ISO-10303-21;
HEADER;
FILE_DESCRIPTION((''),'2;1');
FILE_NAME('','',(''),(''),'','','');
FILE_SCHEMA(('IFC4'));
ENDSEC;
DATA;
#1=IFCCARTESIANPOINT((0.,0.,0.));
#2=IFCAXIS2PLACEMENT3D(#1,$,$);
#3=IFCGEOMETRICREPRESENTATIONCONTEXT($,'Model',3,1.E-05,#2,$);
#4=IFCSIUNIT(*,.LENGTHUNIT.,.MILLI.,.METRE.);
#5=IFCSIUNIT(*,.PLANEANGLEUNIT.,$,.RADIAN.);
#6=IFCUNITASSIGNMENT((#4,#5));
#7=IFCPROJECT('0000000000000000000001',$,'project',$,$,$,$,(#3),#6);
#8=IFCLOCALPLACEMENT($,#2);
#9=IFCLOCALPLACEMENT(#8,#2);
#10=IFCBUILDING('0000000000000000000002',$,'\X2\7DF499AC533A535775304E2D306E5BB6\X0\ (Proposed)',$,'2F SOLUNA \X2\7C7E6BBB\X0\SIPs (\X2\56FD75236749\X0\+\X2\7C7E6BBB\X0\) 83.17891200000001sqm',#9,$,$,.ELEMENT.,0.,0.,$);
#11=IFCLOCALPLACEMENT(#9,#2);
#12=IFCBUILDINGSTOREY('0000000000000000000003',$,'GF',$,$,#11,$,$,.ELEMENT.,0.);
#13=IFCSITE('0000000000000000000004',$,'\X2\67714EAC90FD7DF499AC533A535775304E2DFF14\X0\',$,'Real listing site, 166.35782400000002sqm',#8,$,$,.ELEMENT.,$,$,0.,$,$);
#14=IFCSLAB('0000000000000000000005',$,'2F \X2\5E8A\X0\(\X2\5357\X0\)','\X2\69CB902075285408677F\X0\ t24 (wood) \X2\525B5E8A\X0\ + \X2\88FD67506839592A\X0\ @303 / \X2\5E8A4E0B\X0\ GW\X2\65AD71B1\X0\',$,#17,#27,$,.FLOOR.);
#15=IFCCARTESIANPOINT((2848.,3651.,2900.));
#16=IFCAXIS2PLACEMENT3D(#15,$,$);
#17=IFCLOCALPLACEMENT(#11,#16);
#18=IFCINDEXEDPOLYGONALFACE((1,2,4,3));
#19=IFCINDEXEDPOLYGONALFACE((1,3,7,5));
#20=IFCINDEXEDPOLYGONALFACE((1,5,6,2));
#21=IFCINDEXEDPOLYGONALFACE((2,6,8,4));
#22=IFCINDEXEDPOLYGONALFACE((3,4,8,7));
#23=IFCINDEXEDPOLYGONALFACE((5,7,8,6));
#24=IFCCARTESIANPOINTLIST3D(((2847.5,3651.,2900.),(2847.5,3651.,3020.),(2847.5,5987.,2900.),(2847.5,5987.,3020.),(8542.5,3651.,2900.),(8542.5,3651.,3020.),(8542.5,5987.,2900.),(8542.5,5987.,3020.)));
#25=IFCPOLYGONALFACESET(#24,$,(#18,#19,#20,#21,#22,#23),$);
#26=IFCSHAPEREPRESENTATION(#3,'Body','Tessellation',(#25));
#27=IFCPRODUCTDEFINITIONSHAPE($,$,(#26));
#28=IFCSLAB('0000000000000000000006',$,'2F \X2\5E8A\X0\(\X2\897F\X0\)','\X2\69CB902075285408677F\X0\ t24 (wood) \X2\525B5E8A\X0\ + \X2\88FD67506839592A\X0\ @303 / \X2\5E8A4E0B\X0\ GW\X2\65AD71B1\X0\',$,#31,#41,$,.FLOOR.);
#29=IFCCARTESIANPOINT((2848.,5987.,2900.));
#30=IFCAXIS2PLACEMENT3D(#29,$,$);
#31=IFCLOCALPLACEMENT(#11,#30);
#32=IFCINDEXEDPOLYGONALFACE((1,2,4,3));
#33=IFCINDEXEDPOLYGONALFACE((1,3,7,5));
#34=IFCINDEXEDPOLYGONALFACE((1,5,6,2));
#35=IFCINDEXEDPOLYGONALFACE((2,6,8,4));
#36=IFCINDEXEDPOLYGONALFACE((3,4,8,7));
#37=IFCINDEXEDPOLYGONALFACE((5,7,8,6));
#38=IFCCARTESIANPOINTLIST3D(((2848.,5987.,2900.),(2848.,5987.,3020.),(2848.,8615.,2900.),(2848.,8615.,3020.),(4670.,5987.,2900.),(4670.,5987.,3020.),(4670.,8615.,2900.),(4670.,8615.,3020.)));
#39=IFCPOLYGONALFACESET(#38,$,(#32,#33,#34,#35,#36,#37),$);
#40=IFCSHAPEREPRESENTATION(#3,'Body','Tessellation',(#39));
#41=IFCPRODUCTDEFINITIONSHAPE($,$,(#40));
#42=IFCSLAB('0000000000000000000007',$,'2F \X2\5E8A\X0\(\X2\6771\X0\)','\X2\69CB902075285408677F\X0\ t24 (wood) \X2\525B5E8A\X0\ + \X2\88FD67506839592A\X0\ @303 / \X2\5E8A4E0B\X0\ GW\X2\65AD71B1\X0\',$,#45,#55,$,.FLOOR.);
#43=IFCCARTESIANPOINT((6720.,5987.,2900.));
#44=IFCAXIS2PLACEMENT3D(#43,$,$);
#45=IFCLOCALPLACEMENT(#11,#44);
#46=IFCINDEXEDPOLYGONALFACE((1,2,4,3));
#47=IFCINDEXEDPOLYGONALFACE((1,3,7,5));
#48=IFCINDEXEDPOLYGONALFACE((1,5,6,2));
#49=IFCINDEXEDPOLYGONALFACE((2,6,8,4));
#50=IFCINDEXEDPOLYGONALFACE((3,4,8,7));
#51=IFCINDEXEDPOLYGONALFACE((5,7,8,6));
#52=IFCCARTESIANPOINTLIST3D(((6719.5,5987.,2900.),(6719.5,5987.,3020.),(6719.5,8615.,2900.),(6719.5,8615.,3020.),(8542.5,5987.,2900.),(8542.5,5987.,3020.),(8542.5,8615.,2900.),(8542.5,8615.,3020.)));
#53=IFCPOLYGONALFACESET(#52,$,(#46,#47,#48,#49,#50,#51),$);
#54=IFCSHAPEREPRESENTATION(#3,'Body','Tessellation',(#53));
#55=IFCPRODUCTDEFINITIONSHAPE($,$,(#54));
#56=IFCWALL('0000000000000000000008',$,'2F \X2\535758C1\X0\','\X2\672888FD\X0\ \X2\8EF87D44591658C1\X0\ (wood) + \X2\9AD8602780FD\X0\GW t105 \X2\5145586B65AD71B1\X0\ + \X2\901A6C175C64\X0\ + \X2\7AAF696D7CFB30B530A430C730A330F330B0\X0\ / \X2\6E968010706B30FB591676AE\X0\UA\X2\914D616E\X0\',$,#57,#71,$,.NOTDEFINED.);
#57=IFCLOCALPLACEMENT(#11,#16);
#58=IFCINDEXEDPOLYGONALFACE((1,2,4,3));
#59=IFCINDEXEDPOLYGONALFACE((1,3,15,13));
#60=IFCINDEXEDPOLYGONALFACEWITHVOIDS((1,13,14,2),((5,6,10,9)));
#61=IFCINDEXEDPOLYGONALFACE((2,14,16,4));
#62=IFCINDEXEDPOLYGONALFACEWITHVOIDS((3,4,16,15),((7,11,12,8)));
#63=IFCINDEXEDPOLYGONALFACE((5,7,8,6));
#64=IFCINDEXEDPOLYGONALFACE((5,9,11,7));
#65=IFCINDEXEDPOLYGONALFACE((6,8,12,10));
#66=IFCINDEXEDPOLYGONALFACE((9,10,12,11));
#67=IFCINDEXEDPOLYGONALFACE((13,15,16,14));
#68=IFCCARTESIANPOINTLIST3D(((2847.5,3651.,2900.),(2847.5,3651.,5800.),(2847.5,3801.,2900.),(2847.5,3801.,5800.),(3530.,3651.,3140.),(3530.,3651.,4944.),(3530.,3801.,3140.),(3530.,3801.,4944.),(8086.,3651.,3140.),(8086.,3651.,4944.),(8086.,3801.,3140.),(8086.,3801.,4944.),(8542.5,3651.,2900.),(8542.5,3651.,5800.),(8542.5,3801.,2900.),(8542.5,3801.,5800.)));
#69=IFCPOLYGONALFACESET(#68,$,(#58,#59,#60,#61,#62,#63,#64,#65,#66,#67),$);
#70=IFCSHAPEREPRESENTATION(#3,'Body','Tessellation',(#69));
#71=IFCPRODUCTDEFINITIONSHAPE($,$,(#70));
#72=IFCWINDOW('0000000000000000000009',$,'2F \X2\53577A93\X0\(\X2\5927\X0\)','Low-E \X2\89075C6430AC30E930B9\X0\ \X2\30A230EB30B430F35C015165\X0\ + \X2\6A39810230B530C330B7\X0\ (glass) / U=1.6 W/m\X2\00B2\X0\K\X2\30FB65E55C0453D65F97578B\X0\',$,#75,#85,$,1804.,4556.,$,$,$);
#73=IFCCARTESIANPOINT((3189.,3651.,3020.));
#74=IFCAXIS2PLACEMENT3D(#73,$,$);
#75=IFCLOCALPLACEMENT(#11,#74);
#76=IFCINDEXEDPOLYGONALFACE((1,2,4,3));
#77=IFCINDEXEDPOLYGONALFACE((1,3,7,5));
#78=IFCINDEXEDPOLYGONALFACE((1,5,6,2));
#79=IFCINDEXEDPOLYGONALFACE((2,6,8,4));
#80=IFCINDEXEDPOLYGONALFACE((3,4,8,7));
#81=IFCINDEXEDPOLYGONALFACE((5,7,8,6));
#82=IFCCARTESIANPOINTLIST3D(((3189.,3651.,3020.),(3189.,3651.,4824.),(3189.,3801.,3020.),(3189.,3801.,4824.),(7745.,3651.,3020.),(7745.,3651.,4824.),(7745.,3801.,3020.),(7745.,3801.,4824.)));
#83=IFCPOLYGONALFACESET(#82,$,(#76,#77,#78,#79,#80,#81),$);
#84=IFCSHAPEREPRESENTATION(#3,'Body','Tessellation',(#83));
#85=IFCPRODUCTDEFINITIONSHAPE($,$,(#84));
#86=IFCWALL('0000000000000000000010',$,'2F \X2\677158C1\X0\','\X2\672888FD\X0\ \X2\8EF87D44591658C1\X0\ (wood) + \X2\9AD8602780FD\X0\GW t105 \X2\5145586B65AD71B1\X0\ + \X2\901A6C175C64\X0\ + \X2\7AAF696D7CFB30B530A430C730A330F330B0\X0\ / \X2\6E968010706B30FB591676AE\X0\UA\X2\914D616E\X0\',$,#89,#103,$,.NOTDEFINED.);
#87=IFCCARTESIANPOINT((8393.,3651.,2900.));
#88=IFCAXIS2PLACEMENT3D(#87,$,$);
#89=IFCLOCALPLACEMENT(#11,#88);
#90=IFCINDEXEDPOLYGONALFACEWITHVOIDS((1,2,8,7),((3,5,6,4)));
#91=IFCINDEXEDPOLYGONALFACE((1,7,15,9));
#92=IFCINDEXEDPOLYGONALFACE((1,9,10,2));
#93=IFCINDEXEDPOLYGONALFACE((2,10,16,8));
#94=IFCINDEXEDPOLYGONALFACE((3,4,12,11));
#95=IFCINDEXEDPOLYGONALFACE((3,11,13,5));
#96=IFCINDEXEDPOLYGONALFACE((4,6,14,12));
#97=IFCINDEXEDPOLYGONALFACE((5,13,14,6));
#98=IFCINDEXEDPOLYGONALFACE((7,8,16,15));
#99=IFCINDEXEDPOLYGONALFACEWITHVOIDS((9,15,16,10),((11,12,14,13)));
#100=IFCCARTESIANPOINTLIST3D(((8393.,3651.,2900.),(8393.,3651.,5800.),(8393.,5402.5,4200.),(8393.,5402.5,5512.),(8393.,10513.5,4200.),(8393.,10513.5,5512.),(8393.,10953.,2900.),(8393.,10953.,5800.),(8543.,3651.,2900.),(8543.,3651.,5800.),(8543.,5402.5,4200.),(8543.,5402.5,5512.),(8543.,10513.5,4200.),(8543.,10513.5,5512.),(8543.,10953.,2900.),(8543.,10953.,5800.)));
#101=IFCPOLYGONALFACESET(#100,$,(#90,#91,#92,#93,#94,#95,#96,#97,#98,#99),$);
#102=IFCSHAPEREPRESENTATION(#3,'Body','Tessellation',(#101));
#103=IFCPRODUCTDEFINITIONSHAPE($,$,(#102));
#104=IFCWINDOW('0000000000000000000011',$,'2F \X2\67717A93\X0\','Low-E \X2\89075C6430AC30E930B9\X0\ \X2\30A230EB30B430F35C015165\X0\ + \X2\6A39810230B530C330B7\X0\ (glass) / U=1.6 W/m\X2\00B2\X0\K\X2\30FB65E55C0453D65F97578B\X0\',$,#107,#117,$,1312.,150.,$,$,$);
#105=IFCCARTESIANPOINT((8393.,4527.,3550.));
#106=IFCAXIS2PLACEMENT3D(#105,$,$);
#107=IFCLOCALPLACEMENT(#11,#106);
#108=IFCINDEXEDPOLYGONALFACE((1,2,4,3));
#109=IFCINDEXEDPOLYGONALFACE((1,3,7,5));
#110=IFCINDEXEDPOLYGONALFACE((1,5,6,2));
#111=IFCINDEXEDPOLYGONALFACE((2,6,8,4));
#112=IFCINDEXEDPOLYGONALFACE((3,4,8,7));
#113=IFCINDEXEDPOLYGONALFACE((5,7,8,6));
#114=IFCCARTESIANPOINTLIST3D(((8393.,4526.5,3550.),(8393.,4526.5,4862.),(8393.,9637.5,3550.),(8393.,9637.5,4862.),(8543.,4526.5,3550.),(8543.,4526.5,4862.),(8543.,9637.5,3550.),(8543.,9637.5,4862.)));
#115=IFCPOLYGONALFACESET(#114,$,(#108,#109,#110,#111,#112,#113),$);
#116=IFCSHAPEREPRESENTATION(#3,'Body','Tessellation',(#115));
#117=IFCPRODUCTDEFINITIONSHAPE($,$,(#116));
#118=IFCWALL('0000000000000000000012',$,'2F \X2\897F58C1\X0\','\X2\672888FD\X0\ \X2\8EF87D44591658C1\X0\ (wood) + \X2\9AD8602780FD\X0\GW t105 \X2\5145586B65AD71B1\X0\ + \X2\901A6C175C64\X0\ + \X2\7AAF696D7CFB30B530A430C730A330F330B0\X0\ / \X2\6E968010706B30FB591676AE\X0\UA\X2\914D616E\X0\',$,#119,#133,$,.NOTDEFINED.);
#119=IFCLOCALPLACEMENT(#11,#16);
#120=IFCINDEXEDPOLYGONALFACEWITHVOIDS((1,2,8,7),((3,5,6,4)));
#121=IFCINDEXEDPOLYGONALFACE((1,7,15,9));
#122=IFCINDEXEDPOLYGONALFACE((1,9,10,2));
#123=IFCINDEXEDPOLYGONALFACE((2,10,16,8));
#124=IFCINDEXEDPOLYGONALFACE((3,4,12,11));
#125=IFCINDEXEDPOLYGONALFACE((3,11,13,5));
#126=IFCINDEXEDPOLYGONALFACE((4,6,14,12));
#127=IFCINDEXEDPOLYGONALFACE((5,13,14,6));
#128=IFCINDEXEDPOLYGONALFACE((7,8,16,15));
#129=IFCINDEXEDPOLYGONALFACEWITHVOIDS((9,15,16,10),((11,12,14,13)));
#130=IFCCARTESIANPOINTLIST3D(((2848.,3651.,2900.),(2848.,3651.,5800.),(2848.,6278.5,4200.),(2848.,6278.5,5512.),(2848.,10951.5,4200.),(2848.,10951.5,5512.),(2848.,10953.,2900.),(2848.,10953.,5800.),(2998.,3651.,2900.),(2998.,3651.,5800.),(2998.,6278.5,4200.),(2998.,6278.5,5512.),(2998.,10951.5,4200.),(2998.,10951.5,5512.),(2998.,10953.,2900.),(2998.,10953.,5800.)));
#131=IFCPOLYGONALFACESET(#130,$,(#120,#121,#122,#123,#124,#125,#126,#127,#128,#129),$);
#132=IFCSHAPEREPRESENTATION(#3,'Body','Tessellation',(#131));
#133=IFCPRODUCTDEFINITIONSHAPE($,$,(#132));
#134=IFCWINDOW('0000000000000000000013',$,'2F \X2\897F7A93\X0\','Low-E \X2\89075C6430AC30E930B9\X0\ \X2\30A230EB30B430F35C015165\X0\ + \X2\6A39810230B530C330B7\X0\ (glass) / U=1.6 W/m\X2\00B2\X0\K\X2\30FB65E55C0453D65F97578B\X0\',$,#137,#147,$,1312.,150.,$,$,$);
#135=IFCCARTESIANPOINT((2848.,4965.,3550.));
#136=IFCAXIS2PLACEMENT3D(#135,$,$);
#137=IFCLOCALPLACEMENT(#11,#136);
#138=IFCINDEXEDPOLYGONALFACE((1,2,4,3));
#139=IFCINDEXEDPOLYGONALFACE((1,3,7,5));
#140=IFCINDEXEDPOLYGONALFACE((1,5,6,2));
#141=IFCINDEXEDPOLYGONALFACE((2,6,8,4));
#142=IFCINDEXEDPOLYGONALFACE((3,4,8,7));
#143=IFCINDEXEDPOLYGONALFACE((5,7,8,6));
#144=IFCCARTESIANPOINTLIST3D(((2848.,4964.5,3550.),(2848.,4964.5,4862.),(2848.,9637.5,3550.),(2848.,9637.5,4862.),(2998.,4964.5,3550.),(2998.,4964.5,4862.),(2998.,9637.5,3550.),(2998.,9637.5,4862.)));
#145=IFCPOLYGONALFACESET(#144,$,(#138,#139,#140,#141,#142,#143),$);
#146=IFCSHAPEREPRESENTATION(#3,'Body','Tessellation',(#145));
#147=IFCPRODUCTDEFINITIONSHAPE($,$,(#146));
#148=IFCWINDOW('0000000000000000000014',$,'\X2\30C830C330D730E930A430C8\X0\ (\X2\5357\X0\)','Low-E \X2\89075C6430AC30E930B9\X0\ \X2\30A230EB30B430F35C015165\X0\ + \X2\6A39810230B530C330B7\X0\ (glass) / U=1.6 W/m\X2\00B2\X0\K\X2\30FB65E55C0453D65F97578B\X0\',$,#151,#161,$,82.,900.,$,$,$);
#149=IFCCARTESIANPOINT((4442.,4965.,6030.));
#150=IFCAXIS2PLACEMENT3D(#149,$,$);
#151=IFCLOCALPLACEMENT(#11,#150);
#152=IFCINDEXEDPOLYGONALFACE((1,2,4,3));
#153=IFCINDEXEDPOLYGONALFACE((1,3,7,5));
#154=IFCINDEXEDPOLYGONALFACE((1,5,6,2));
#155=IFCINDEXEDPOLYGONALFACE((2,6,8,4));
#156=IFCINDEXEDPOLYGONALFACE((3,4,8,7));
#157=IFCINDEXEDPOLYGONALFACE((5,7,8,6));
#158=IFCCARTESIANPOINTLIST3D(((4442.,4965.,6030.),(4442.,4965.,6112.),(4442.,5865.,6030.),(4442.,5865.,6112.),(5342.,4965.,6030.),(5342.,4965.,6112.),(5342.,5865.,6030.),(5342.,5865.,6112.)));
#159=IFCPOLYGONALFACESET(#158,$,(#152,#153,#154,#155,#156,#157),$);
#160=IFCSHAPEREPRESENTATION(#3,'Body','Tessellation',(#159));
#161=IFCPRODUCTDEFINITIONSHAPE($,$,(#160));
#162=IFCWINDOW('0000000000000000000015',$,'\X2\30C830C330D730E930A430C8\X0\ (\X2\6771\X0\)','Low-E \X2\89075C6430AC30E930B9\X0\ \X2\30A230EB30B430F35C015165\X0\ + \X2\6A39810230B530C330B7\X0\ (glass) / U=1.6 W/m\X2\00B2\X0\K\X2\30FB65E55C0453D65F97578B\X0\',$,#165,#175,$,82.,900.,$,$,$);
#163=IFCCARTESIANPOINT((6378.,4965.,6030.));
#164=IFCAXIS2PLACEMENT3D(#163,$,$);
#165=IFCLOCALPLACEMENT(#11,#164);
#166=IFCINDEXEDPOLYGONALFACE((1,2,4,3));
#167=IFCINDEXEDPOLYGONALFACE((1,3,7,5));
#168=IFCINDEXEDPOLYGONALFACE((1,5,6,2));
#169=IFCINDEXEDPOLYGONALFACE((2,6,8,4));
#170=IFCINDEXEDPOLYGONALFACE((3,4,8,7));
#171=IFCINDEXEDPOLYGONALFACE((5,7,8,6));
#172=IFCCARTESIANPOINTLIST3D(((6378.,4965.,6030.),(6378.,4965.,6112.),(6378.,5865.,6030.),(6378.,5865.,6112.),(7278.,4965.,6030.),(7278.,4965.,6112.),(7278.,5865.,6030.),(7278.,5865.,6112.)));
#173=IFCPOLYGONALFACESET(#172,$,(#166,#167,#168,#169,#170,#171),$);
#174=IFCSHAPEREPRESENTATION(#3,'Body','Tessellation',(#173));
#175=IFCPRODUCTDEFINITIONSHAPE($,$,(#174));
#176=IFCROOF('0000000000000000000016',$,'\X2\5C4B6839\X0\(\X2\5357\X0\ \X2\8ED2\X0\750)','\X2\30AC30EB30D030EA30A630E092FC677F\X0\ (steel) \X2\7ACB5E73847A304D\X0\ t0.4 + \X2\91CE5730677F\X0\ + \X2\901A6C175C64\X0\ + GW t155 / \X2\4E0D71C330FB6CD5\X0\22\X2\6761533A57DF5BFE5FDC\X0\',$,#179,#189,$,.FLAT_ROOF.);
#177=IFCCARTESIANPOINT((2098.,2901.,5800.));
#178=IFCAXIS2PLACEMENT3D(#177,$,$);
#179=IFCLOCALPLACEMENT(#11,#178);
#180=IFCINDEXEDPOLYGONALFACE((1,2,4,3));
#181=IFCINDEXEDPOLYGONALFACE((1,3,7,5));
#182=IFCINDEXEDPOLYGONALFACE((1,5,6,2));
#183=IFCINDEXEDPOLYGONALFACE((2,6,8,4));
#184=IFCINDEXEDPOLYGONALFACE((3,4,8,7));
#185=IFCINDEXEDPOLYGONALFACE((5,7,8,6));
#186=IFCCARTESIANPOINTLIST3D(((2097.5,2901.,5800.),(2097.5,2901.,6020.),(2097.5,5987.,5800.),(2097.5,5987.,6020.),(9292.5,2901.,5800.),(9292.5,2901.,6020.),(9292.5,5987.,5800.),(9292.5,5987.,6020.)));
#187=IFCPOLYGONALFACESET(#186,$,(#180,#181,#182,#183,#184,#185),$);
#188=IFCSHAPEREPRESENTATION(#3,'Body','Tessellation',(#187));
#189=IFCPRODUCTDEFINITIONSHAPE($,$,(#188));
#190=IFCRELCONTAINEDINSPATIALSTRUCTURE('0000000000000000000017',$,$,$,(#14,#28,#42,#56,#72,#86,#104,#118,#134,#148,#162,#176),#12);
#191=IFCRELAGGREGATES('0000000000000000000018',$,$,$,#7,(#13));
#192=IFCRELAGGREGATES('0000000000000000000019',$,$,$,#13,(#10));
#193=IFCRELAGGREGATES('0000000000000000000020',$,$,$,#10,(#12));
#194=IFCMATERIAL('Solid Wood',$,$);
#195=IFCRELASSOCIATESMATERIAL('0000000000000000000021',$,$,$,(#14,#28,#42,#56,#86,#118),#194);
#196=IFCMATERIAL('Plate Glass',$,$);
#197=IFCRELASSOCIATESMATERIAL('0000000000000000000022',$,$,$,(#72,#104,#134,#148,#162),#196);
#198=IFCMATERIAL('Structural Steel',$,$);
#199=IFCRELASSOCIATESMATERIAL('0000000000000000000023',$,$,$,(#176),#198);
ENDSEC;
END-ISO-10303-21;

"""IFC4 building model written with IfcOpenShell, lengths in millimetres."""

from ifc_helpers import new_model, si_unit, frame, frame_2d, origin, place, context, project, spatial, rectangle, extrude, material, element, fill, save


model = new_model("IFC4")

# Units and contexts
model_context = context("Model", 3, precision=1e-05, world=origin())
ifc_project = project(units=[si_unit("LENGTHUNIT", "METRE", prefix="MILLI"), si_unit("PLANEANGLEUNIT", "RADIAN")], contexts=[model_context])

# Site, building, storey
site_placement = place(None, origin())
site = spatial("IfcSite", under=ifc_project, at=site_placement, Name="東京都練馬区南田中４", ObjectType="Real listing site, 166.35782400000002sqm", CompositionType="ELEMENT", RefElevation=0.0)
building_placement = place(site_placement, origin())
building = spatial("IfcBuilding", under=site, at=building_placement, Name="練馬区南田中の家 (Proposed)", ObjectType="2F SOLUNA 籾殻SIPs (国産杉+籾殻) 83.17891200000001sqm", CompositionType="ELEMENT", ElevationOfRefHeight=0.0, ElevationOfTerrain=0.0)
storey_placement = place(building_placement, origin())
storey = spatial("IfcBuildingStorey", under=building, at=storey_placement, Name="GF", CompositionType="ELEMENT", Elevation=0.0)

# Slabs
ifc_material_1 = material(Name="Solid Wood")
slab_1_placement = place(storey_placement, frame((2848.0, 3651.0, 2900.0)))
element("IfcSlab", 1, at=slab_1_placement, inside=storey, material=ifc_material_1, Name="2F 床(南)", Description="構造用合板 t24 (wood) 剛床 + 製材根太 @303 / 床下 GW断熱", PredefinedType="FLOOR", context=model_context, shape_type="SweptSolid", body=[
    extrude(rectangle(XDim=5695.0, YDim=2336.0, at=frame_2d((2847.0, 1168.0))), frame((2848.0, 3651.0, 2900.0)), (0.0, 0.0, 1.0), 120.0),
])
slab_2_placement = place(storey_placement, frame((2848.0, 5987.0, 2900.0)))
element("IfcSlab", 2, at=slab_2_placement, inside=storey, material=ifc_material_1, Name="2F 床(西)", Description="構造用合板 t24 (wood) 剛床 + 製材根太 @303 / 床下 GW断熱", PredefinedType="FLOOR", context=model_context, shape_type="SweptSolid", body=[
    extrude(rectangle(XDim=1822.0, YDim=2628.0, at=frame_2d((911.0, 1314.0))), frame((2848.0, 5987.0, 2900.0)), (0.0, 0.0, 1.0), 120.0),
])
slab_3_placement = place(storey_placement, frame((6720.0, 5987.0, 2900.0)))
element("IfcSlab", 3, at=slab_3_placement, inside=storey, material=ifc_material_1, Name="2F 床(東)", Description="構造用合板 t24 (wood) 剛床 + 製材根太 @303 / 床下 GW断熱", PredefinedType="FLOOR", context=model_context, shape_type="SweptSolid", body=[
    extrude(rectangle(XDim=1823.0, YDim=2628.0, at=frame_2d((911.0, 1314.0))), frame((6720.0, 5987.0, 2900.0)), (0.0, 0.0, 1.0), 120.0),
])

# Walls, openings, windows
wall_1_placement = place(storey_placement, frame((2848.0, 3651.0, 2900.0)))
wall_1 = element("IfcWall", 4, at=wall_1_placement, inside=storey, material=ifc_material_1, Name="2F 南壁", Description="木製 軸組外壁 (wood) + 高性能GW t105 充填断熱 + 通気層 + 窯業系サイディング / 準耐火・外皮UA配慮", PredefinedType="NOTDEFINED", context=model_context, shape_type="SweptSolid", body=[
    extrude(rectangle(XDim=5695.0, YDim=150.0, at=frame_2d((2847.0, 75.0))), frame((2848.0, 3651.0, 2900.0)), (0.0, 0.0, 1.0), 2900.0),
])
opening_1_placement = place(storey_placement, frame((3189.0, 3651.0, 3020.0)))
opening_1 = element("IfcOpeningElement", 5, at=opening_1_placement, cuts=wall_1, PredefinedType="NOTDEFINED", context=model_context, shape_type="SweptSolid", body=[
    extrude(rectangle(XDim=4556.0, YDim=150.0, at=frame_2d((2278.0, 75.0))), frame((3189.0, 3651.0, 3020.0)), (0.0, 0.0, 1.0), 1804.0),
])
ifc_material_2 = material(Name="Plate Glass")
window_1_placement = place(storey_placement, frame((3189.0, 3651.0, 3020.0)))
window_1 = element("IfcWindow", 6, at=window_1_placement, inside=storey, material=ifc_material_2, Name="2F 南窓(大)", Description="Low-E 複層ガラス アルゴン封入 + 樹脂サッシ (glass) / U=1.6 W/m²K・日射取得型", OverallHeight=1804.0, OverallWidth=4556.0, context=model_context, shape_type="SweptSolid", body=[
    extrude(rectangle(XDim=4556.0, YDim=150.0, at=frame_2d((2278.0, 75.0))), frame((3189.0, 3651.0, 3020.0)), (0.0, 0.0, 1.0), 1804.0),
])
fill(opening_1, window_1)
wall_2_placement = place(storey_placement, frame((8393.0, 3651.0, 2900.0)))
wall_2 = element("IfcWall", 7, at=wall_2_placement, inside=storey, material=ifc_material_1, Name="2F 東壁", Description="木製 軸組外壁 (wood) + 高性能GW t105 充填断熱 + 通気層 + 窯業系サイディング / 準耐火・外皮UA配慮", PredefinedType="NOTDEFINED", context=model_context, shape_type="SweptSolid", body=[
    extrude(rectangle(XDim=150.0, YDim=7302.0, at=frame_2d((75.0, 3651.0))), frame((8393.0, 3651.0, 2900.0)), (0.0, 0.0, 1.0), 2900.0),
])
opening_2_placement = place(storey_placement, frame((8393.0, 4527.0, 3550.0)))
opening_2 = element("IfcOpeningElement", 8, at=opening_2_placement, cuts=wall_2, PredefinedType="NOTDEFINED", context=model_context, shape_type="SweptSolid", body=[
    extrude(rectangle(XDim=150.0, YDim=5111.0, at=frame_2d((75.0, 2555.0))), frame((8393.0, 4527.0, 3550.0)), (0.0, 0.0, 1.0), 1312.0),
])
window_2_placement = place(storey_placement, frame((8393.0, 4527.0, 3550.0)))
window_2 = element("IfcWindow", 9, at=window_2_placement, inside=storey, material=ifc_material_2, Name="2F 東窓", Description="Low-E 複層ガラス アルゴン封入 + 樹脂サッシ (glass) / U=1.6 W/m²K・日射取得型", OverallHeight=1312.0, OverallWidth=150.0, context=model_context, shape_type="SweptSolid", body=[
    extrude(rectangle(XDim=150.0, YDim=5111.0, at=frame_2d((75.0, 2555.0))), frame((8393.0, 4527.0, 3550.0)), (0.0, 0.0, 1.0), 1312.0),
])
fill(opening_2, window_2)
wall_3_placement = place(storey_placement, frame((2848.0, 3651.0, 2900.0)))
wall_3 = element("IfcWall", 10, at=wall_3_placement, inside=storey, material=ifc_material_1, Name="2F 西壁", Description="木製 軸組外壁 (wood) + 高性能GW t105 充填断熱 + 通気層 + 窯業系サイディング / 準耐火・外皮UA配慮", PredefinedType="NOTDEFINED", context=model_context, shape_type="SweptSolid", body=[
    extrude(rectangle(XDim=150.0, YDim=7302.0, at=frame_2d((75.0, 3651.0))), frame((2848.0, 3651.0, 2900.0)), (0.0, 0.0, 1.0), 2900.0),
])
opening_3_placement = place(storey_placement, frame((2848.0, 4965.0, 3550.0)))
opening_3 = element("IfcOpeningElement", 11, at=opening_3_placement, cuts=wall_3, PredefinedType="NOTDEFINED", context=model_context, shape_type="SweptSolid", body=[
    extrude(rectangle(XDim=150.0, YDim=4673.0, at=frame_2d((75.0, 2336.0))), frame((2848.0, 4965.0, 3550.0)), (0.0, 0.0, 1.0), 1312.0),
])
window_3_placement = place(storey_placement, frame((2848.0, 4965.0, 3550.0)))
window_3 = element("IfcWindow", 12, at=window_3_placement, inside=storey, material=ifc_material_2, Name="2F 西窓", Description="Low-E 複層ガラス アルゴン封入 + 樹脂サッシ (glass) / U=1.6 W/m²K・日射取得型", OverallHeight=1312.0, OverallWidth=150.0, context=model_context, shape_type="SweptSolid", body=[
    extrude(rectangle(XDim=150.0, YDim=4673.0, at=frame_2d((75.0, 2336.0))), frame((2848.0, 4965.0, 3550.0)), (0.0, 0.0, 1.0), 1312.0),
])
fill(opening_3, window_3)

# Windows
window_4_placement = place(storey_placement, frame((4442.0, 4965.0, 6030.0)))
element("IfcWindow", 13, at=window_4_placement, inside=storey, material=ifc_material_2, Name="トップライト (南)", Description="Low-E 複層ガラス アルゴン封入 + 樹脂サッシ (glass) / U=1.6 W/m²K・日射取得型", OverallHeight=82.0, OverallWidth=900.0, context=model_context, shape_type="SweptSolid", body=[
    extrude(rectangle(XDim=900.0, YDim=900.0, at=frame_2d((450.0, 450.0))), frame((4442.0, 4965.0, 6030.0)), (0.0, 0.0, 1.0), 82.0),
])
window_5_placement = place(storey_placement, frame((6378.0, 4965.0, 6030.0)))
element("IfcWindow", 14, at=window_5_placement, inside=storey, material=ifc_material_2, Name="トップライト (東)", Description="Low-E 複層ガラス アルゴン封入 + 樹脂サッシ (glass) / U=1.6 W/m²K・日射取得型", OverallHeight=82.0, OverallWidth=900.0, context=model_context, shape_type="SweptSolid", body=[
    extrude(rectangle(XDim=900.0, YDim=900.0, at=frame_2d((450.0, 450.0))), frame((6378.0, 4965.0, 6030.0)), (0.0, 0.0, 1.0), 82.0),
])

# Roof
ifc_material_3 = material(Name="Structural Steel")
roof_1_placement = place(storey_placement, frame((2098.0, 2901.0, 5800.0)))
element("IfcRoof", 15, at=roof_1_placement, inside=storey, material=ifc_material_3, Name="屋根(南 軒750)", Description="ガルバリウム鋼板 (steel) 立平葺き t0.4 + 野地板 + 通気層 + GW t155 / 不燃・法22条区域対応", PredefinedType="FLAT_ROOF", context=model_context, shape_type="SweptSolid", body=[
    extrude(rectangle(XDim=7195.0, YDim=3086.0, at=frame_2d((3597.0, 1543.0))), frame((2098.0, 2901.0, 5800.0)), (0.0, 0.0, 1.0), 220.0),
])

save(model, "model.ifc")
